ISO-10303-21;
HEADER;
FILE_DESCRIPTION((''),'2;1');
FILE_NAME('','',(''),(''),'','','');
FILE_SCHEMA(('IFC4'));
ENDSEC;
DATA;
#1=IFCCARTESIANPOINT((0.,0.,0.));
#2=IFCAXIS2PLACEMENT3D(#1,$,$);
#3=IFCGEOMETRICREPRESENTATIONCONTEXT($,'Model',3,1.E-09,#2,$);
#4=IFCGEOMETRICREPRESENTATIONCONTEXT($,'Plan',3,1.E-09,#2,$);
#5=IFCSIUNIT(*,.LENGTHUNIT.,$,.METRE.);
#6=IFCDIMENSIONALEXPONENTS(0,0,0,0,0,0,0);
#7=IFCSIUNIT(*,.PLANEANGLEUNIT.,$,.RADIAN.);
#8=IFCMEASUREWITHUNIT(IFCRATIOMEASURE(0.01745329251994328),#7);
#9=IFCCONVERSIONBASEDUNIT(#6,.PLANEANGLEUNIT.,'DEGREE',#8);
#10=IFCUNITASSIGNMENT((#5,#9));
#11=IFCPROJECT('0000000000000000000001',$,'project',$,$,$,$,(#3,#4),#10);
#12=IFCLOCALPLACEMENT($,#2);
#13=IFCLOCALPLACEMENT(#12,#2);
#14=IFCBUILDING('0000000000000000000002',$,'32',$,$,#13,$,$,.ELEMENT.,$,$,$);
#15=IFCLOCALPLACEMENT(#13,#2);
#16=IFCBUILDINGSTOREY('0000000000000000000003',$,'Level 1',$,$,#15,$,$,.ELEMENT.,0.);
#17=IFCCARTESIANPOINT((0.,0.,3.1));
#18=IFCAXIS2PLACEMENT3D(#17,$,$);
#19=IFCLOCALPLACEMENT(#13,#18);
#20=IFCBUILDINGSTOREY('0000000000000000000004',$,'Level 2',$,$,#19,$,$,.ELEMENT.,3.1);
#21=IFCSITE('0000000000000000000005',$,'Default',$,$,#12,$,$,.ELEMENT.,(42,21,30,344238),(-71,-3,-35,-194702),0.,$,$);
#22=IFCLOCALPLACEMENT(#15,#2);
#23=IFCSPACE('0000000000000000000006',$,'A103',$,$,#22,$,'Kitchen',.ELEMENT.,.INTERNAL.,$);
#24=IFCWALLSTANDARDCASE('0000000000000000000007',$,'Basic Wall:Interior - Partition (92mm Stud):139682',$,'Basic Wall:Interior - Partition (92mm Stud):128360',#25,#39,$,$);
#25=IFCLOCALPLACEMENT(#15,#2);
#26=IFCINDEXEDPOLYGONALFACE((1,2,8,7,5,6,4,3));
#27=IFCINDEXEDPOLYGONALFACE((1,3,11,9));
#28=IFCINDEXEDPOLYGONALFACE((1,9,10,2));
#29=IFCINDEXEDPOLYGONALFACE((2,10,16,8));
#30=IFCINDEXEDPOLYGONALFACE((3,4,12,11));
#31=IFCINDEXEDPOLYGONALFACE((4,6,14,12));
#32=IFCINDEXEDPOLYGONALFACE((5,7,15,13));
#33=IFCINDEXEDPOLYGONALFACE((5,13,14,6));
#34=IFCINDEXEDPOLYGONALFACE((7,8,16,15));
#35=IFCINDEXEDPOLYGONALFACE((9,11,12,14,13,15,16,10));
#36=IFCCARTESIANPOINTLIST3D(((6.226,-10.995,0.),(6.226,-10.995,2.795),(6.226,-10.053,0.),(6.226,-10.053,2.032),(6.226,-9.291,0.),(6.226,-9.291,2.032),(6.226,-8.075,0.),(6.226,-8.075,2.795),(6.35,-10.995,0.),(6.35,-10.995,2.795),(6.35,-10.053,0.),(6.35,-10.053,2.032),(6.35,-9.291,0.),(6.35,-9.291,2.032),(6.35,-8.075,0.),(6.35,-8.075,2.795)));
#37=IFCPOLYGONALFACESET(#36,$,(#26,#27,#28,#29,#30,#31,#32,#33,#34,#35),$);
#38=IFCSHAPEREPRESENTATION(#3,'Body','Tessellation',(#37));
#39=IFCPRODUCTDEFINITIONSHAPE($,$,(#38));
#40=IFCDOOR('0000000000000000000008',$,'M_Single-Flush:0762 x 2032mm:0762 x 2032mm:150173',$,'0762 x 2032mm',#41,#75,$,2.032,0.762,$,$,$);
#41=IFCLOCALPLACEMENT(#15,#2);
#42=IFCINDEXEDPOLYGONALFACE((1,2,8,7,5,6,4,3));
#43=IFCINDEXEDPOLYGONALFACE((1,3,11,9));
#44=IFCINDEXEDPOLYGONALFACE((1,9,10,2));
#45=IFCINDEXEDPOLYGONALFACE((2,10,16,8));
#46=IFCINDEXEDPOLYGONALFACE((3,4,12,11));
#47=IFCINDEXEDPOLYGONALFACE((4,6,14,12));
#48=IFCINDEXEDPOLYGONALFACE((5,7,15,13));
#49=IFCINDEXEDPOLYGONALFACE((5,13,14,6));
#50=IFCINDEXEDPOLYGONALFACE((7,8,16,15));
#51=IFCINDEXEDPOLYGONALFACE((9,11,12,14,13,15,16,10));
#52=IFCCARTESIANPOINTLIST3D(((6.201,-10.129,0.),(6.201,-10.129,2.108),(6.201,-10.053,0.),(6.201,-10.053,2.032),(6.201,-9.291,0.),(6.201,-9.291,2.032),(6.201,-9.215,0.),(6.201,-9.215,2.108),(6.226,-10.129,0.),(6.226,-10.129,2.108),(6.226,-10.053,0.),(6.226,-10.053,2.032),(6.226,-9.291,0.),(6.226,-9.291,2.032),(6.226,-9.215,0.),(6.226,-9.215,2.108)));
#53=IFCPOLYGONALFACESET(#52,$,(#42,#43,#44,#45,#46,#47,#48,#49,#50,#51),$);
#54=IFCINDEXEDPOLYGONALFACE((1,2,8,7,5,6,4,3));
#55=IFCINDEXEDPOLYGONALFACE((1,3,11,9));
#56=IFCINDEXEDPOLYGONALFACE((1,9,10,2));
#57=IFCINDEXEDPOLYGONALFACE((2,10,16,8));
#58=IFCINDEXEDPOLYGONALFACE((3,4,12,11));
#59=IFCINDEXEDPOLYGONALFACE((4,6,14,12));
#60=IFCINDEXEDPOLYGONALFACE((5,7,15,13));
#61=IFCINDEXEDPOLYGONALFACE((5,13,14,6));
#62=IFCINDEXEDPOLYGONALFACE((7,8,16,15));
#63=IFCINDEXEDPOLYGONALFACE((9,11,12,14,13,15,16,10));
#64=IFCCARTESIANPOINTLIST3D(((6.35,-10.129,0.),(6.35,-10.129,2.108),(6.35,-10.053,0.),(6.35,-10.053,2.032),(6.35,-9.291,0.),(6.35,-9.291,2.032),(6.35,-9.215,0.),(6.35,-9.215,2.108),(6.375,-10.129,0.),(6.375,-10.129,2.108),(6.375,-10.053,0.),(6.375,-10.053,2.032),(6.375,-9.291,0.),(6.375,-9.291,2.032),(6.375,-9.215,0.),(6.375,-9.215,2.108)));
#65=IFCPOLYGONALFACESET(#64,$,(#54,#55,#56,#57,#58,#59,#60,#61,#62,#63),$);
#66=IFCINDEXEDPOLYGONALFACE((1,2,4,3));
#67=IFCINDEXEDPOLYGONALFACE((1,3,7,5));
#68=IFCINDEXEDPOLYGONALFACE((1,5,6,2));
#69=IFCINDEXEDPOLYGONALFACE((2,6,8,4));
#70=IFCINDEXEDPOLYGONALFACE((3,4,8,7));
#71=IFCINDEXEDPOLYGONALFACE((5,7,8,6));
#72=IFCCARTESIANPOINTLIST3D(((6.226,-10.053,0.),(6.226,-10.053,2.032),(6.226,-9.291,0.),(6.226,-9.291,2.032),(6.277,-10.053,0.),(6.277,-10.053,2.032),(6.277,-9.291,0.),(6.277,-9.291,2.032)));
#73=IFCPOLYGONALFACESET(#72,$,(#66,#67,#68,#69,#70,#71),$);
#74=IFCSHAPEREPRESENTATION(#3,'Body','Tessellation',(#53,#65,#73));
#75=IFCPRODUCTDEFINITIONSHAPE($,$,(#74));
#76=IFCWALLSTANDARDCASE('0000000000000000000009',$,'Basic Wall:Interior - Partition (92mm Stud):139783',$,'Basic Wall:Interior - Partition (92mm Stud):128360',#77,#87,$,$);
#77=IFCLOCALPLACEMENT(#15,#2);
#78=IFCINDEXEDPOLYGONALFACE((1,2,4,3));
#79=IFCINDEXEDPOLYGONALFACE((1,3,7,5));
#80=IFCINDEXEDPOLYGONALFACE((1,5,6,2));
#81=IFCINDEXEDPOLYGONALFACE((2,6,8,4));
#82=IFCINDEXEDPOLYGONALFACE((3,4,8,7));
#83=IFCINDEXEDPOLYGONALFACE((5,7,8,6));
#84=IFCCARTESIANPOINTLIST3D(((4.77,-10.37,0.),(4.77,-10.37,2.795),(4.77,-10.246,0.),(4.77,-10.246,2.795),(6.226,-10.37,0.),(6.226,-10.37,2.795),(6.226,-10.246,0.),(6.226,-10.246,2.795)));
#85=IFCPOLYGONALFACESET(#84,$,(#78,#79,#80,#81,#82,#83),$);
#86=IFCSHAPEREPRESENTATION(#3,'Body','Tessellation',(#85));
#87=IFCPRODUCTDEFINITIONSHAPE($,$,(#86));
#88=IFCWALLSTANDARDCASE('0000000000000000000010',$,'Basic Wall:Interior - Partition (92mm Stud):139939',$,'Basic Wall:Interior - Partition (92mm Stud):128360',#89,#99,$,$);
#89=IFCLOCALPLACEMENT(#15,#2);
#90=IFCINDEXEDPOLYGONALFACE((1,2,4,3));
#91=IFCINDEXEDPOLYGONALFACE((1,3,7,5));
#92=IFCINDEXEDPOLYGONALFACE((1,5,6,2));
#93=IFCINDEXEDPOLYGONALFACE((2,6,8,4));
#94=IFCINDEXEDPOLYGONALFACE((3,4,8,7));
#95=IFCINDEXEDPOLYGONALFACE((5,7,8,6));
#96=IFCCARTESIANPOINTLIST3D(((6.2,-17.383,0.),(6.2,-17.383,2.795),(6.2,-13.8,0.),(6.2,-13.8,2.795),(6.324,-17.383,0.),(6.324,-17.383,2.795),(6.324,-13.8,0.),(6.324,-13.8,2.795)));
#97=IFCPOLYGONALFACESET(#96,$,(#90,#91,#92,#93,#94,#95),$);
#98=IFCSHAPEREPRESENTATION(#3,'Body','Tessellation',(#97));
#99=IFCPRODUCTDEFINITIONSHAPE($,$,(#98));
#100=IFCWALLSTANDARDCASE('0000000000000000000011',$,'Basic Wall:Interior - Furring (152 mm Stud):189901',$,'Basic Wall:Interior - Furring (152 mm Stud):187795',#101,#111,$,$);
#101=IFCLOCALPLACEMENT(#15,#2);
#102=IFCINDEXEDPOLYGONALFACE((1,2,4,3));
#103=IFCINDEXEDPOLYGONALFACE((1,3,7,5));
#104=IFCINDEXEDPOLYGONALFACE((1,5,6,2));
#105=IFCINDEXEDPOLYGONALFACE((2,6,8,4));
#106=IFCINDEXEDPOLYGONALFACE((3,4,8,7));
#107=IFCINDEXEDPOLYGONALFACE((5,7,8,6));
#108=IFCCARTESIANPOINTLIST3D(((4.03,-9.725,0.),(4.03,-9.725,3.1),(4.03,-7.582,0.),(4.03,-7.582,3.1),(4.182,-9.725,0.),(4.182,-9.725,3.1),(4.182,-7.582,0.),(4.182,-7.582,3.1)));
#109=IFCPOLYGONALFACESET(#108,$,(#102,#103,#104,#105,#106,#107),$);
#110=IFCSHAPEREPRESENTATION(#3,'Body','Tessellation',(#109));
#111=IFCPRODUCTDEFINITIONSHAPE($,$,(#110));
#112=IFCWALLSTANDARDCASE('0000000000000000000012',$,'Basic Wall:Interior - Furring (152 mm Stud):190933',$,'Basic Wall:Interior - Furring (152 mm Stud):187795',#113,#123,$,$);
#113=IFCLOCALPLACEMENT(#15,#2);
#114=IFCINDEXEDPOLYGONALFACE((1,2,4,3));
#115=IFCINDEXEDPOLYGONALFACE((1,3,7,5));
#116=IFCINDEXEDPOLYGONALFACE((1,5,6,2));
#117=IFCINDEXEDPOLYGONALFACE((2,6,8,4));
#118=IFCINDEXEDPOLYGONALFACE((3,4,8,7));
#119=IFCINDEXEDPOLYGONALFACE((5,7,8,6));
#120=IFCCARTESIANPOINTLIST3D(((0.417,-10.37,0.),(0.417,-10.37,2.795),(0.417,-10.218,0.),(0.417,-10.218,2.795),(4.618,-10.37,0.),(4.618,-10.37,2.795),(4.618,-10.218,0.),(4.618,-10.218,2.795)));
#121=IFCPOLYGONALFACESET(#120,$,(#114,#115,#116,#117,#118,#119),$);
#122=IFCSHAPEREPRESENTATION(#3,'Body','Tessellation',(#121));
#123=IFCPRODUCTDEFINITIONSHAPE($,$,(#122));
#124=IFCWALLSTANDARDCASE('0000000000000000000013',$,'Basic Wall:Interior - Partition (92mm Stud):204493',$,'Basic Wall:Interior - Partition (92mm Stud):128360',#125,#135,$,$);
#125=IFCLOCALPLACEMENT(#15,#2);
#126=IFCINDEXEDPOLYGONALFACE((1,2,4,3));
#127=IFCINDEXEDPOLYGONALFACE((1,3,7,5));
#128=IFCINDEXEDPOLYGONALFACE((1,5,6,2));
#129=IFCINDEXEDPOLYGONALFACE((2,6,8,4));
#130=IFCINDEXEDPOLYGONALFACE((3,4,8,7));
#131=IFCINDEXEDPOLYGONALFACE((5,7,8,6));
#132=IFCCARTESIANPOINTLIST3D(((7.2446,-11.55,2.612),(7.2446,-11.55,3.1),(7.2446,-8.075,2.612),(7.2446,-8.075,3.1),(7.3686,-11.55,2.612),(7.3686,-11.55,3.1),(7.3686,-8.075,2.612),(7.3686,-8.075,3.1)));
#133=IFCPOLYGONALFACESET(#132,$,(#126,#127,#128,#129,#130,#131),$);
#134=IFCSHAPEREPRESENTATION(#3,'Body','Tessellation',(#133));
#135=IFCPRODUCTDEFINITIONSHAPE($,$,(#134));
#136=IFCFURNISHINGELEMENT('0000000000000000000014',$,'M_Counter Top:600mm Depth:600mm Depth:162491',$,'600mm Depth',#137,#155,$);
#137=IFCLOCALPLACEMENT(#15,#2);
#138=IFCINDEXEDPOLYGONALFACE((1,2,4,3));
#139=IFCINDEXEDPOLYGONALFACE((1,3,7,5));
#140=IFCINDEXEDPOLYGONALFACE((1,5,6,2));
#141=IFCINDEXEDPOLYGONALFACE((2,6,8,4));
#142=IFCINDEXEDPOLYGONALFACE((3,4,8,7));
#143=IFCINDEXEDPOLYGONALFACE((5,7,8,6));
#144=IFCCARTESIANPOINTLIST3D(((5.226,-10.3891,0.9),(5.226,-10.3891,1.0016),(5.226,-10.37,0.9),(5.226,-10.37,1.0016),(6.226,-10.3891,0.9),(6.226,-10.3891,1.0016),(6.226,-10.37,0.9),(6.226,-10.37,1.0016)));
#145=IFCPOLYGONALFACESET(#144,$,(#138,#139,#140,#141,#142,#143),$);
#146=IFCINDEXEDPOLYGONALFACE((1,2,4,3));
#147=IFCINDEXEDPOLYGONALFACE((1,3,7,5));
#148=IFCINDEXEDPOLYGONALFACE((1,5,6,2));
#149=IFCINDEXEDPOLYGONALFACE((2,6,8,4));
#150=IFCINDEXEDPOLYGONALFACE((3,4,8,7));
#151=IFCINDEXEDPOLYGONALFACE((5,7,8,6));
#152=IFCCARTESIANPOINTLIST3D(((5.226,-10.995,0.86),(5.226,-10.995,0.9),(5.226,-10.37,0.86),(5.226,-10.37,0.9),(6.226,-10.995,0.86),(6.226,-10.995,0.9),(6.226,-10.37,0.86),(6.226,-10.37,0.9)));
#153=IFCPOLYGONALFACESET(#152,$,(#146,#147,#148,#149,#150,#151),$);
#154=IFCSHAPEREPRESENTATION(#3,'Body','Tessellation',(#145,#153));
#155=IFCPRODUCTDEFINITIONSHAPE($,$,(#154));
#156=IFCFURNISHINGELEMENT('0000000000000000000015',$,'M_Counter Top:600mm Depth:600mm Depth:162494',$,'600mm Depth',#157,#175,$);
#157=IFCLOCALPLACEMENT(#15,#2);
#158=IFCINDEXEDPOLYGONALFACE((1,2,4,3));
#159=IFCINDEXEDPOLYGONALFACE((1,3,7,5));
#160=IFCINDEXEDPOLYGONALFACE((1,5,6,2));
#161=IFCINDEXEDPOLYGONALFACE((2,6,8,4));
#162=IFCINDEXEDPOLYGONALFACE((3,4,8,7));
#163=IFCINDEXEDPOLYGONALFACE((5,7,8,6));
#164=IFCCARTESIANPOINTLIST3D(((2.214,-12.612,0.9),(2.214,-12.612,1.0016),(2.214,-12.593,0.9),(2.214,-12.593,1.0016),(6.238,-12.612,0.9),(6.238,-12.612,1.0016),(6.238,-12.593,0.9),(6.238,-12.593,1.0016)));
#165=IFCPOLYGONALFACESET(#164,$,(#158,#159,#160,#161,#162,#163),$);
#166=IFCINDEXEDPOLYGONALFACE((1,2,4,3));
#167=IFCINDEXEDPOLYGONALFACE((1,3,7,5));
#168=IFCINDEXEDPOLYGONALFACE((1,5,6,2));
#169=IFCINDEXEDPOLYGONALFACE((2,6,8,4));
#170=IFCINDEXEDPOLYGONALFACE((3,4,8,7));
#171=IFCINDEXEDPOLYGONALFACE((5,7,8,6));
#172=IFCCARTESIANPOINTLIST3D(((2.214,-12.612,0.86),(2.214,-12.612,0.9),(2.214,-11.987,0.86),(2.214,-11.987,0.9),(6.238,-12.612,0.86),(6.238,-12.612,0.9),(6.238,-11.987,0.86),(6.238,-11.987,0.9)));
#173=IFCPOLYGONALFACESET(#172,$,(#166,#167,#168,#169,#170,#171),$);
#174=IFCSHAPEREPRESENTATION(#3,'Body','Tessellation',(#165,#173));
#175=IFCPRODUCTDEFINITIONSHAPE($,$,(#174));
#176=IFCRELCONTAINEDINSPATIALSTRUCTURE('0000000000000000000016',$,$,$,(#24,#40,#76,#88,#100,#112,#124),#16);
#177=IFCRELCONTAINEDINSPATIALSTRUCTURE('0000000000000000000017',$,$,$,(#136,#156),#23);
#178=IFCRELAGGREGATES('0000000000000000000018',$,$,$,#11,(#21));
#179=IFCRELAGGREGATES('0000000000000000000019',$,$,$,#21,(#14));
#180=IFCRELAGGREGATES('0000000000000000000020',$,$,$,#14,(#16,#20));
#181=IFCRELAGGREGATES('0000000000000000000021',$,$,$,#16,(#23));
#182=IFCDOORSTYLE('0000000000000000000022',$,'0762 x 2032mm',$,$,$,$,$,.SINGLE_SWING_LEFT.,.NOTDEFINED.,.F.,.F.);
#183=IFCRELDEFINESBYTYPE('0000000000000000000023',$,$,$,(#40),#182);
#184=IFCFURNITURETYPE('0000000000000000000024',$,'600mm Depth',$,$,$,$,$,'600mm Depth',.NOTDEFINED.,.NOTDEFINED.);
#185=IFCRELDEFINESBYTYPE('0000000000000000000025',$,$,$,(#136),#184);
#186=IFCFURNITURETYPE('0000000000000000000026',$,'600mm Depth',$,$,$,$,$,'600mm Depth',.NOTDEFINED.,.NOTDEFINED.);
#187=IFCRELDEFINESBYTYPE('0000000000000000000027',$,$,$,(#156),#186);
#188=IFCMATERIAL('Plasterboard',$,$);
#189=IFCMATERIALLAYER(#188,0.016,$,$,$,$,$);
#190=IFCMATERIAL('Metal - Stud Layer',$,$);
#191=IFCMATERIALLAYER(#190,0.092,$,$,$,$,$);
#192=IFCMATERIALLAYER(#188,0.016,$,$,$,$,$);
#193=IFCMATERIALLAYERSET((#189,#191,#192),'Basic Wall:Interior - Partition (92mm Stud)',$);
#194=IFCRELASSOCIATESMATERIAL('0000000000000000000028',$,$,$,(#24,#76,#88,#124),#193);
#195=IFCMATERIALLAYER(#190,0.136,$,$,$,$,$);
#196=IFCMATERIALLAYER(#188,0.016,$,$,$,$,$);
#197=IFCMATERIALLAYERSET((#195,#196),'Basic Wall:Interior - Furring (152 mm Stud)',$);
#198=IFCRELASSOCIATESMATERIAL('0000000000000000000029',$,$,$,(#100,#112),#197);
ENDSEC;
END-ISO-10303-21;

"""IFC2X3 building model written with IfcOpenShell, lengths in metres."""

from ifc_helpers import new_model, entity, si_unit, converted_unit, frame, frame_2d, origin, origin_2d_with_axis, place, context, project, spatial, polyline, rectangle, outline, extrude, source, transform, mapped, material, layer, layer_set, layer_usage, type_object, type_shapes, element, fill, save


model = new_model("IFC2X3")

# Units and contexts
model_context = context("Model", 3, precision=1e-09, world=origin())
plan_context = context("Plan", 3, precision=1e-09, world=origin())
ifc_project = project(units=[si_unit("LENGTHUNIT", "METRE"), converted_unit("PLANEANGLEUNIT", "DEGREE", entity("IfcRatioMeasure", 0.01745329251994328), si_unit("PLANEANGLEUNIT", "RADIAN"), dimensions=[0, 0, 0, 0, 0, 0, 0])], contexts=[model_context, plan_context])

# Site, building, storey
site_placement = place(None, origin())
site = spatial("IfcSite", under=ifc_project, at=site_placement, Name="Default", CompositionType="ELEMENT", RefLatitude=(42, 21, 30, 344238), RefLongitude=(-71, -3, -35, -194702), RefElevation=0.0)
building_placement = place(site_placement, origin())
building = spatial("IfcBuilding", under=site, at=building_placement, Name="32", CompositionType="ELEMENT")
storey_1_placement = place(building_placement, origin())
storey_1 = spatial("IfcBuildingStorey", under=building, at=storey_1_placement, Name="Level 1", CompositionType="ELEMENT", Elevation=0.0)

# Shared definitions
ifc_material_1 = material(Name="Metal - Stud Layer")
ifc_material_2 = material(Name="Plasterboard")

# Wall, opening, door
ifc_layer_1 = layer(ifc_material_2, 0.016)
ifc_layer_2 = layer(ifc_material_1, 0.092)
ifc_layer_3 = layer(ifc_material_2, 0.016)
ifc_layer_set_1 = layer_set([ifc_layer_1, ifc_layer_2, ifc_layer_3], Name="Basic Wall:Interior - Partition (92mm Stud)")
ifc_layer_usage_1 = layer_usage(ifc_layer_set_1, "AXIS2", "NEGATIVE", 0.062)
wall_1_placement = place(storey_1_placement, frame((6.288, -10.995, 0.0), z_axis=(0.0, 0.0, 1.0), x_axis=(0.0, 1.0, 0.0)))
wall_1 = element("IfcWallStandardCase", 1, at=wall_1_placement, inside=storey_1, material=ifc_layer_usage_1, Name="Basic Wall:Interior - Partition (92mm Stud):139682", ObjectType="Basic Wall:Interior - Partition (92mm Stud):128360", context=model_context, shape_type="SweptSolid", body=[
    extrude(rectangle(XDim=2.92, YDim=0.124, at=frame_2d((1.46, 0.0), x_axis=(-1.0, 0.0))), origin(), (0.0, 0.0, 1.0), 2.795),
])
opening_1_placement = place(wall_1_placement, frame((0.942, -0.062, 0.0)))
opening_1 = element("IfcOpeningElement", 2, at=opening_1_placement, cuts=wall_1, ObjectType="Opening", context=model_context, shape_type="SweptSolid", body=[
    extrude(rectangle(XDim=0.762, YDim=2.032, at=frame_2d((1.016, 0.381), x_axis=(0.0, -1.0))), frame((0.0, 0.0, 0.0), z_axis=(0.0, 1.0, 0.0), x_axis=(0.0, 0.0, 1.0)), (0.0, 0.0, 1.0), 0.124),
])
door_style_1 = type_object("IfcDoorStyle", Name="0762 x 2032mm", ConstructionType="NOTDEFINED", OperationType="SINGLE_SWING_LEFT", ParameterTakesPrecedence=False, Sizeable=False)
shared_shape_1 = source(origin(), model_context, "Body", "SweptSolid", [
    extrude(outline(polyline([(-0.457, -1.073), (0.457, -1.073), (0.457, 1.035), (0.381, 1.035), (0.381, -0.997), (-0.381, -0.997), (-0.381, 1.035), (-0.457, 1.035), (-0.457, -1.073)])), frame((0.381, 0.149, 1.035), z_axis=(0.0, -1.0, 0.0), x_axis=(-1.0, 0.0, 0.0)), (0.0, 0.0, 1.0), 0.025),
    extrude(outline(polyline([(-1.073, -0.457), (1.035, -0.457), (1.035, -0.381), (-0.997, -0.381), (-0.997, 0.381), (1.035, 0.381), (1.035, 0.457), (-1.073, 0.457), (-1.073, -0.457)])), frame((0.381, 0.0, 1.035), z_axis=(0.0, -1.0, 0.0), x_axis=(0.0, 0.0, -1.0)), (0.0, 0.0, 1.0), 0.025),
    extrude(rectangle(XDim=0.762, YDim=0.051, at=origin_2d_with_axis()), frame((0.381, 0.0985, 0.0)), (0.0, 0.0, 1.0), 2.032),
])
type_shapes(door_style_1, [shared_shape_1])
door_1_placement = place(opening_1_placement, origin())
door_1 = element("IfcDoor", 3, at=door_1_placement, inside=storey_1, type_object=door_style_1, Name="M_Single-Flush:0762 x 2032mm:0762 x 2032mm:150173", ObjectType="0762 x 2032mm", OverallHeight=2.032, OverallWidth=0.762, context=model_context, shape_type="MappedRepresentation", body=[
    mapped(shared_shape_1, transform((0.0, 0.0, 0.0), scale=1.0)),
])
fill(opening_1, door_1)

# Walls
ifc_layer_usage_2 = layer_usage(ifc_layer_set_1, "AXIS2", "NEGATIVE", 0.062)
wall_2_placement = place(storey_1_placement, frame((4.77, -10.308, 0.0)))
element("IfcWallStandardCase", 4, at=wall_2_placement, inside=storey_1, material=ifc_layer_usage_2, Name="Basic Wall:Interior - Partition (92mm Stud):139783", ObjectType="Basic Wall:Interior - Partition (92mm Stud):128360", context=model_context, shape_type="SweptSolid", body=[
    extrude(rectangle(XDim=1.456, YDim=0.124, at=frame_2d((0.728, 0.0), x_axis=(-1.0, 0.0))), origin(), (0.0, 0.0, 1.0), 2.795),
])
ifc_layer_usage_3 = layer_usage(ifc_layer_set_1, "AXIS2", "NEGATIVE", 0.062)
wall_3_placement = place(storey_1_placement, frame((6.262, -13.8, 0.0), z_axis=(0.0, 0.0, 1.0), x_axis=(0.0, -1.0, 0.0)))
element("IfcWallStandardCase", 5, at=wall_3_placement, inside=storey_1, material=ifc_layer_usage_3, Name="Basic Wall:Interior - Partition (92mm Stud):139939", ObjectType="Basic Wall:Interior - Partition (92mm Stud):128360", context=model_context, shape_type="SweptSolid", body=[
    extrude(rectangle(XDim=3.583, YDim=0.124, at=frame_2d((1.7915, 0.0), x_axis=(-1.0, 0.0))), origin(), (0.0, 0.0, 1.0), 2.795),
])

# Shared definitions
storey_2_placement = place(building_placement, frame((0.0, 0.0, 3.1)))
storey_2 = spatial("IfcBuildingStorey", under=building, at=storey_2_placement, Name="Level 2", CompositionType="ELEMENT", Elevation=3.1)

# Walls
ifc_layer_4 = layer(ifc_material_1, 0.136)
ifc_layer_5 = layer(ifc_material_2, 0.016)
ifc_layer_set_2 = layer_set([ifc_layer_4, ifc_layer_5], Name="Basic Wall:Interior - Furring (152 mm Stud)")
ifc_layer_usage_4 = layer_usage(ifc_layer_set_2, "AXIS2", "POSITIVE", -0.076)
wall_4_placement = place(storey_1_placement, frame((4.106, -9.725, 0.0), z_axis=(0.0, 0.0, 1.0), x_axis=(0.0, 1.0, 0.0)))
element("IfcWallStandardCase", 6, at=wall_4_placement, inside=storey_1, material=ifc_layer_usage_4, Name="Basic Wall:Interior - Furring (152 mm Stud):189901", ObjectType="Basic Wall:Interior - Furring (152 mm Stud):187795", context=model_context, shape_type="SweptSolid", body=[
    extrude(rectangle(XDim=2.143, YDim=0.152, at=frame_2d((1.0715, 0.0), x_axis=(-1.0, 0.0))), origin(), (0.0, 0.0, 1.0), 3.1),
])
ifc_layer_usage_5 = layer_usage(ifc_layer_set_2, "AXIS2", "NEGATIVE", 0.076)
wall_5_placement = place(storey_1_placement, frame((0.417, -10.294, 0.0)))
element("IfcWallStandardCase", 7, at=wall_5_placement, inside=storey_1, material=ifc_layer_usage_5, Name="Basic Wall:Interior - Furring (152 mm Stud):190933", ObjectType="Basic Wall:Interior - Furring (152 mm Stud):187795", context=model_context, shape_type="SweptSolid", body=[
    extrude(rectangle(XDim=4.201, YDim=0.152, at=frame_2d((2.1005, 0.0), x_axis=(-1.0, 0.0))), origin(), (0.0, 0.0, 1.0), 2.795),
])
ifc_layer_usage_6 = layer_usage(ifc_layer_set_1, "AXIS2", "NEGATIVE", 0.062)
wall_6_placement = place(storey_1_placement, frame((7.3066, -11.55, 2.612), z_axis=(0.0, 0.0, 1.0), x_axis=(0.0, 1.0, 0.0)))
element("IfcWallStandardCase", 8, at=wall_6_placement, inside=storey_1, material=ifc_layer_usage_6, Name="Basic Wall:Interior - Partition (92mm Stud):204493", ObjectType="Basic Wall:Interior - Partition (92mm Stud):128360", context=model_context, shape_type="SweptSolid", body=[
    extrude(rectangle(XDim=3.475, YDim=0.124, at=frame_2d((1.7375, 0.0), x_axis=(-1.0, 0.0))), origin(), (0.0, 0.0, 1.0), 0.488),
])

# Shared definitions
space_1_placement = place(storey_1_placement, origin())
space_1 = spatial("IfcSpace", under=storey_1, at=space_1_placement, Name="A103", LongName="Kitchen", CompositionType="ELEMENT", InteriorOrExteriorSpace="INTERNAL")

# Furnishing elements
furniture_type_1 = type_object("IfcFurnitureType", Name="600mm Depth", ElementType="600mm Depth", AssemblyPlace="NOTDEFINED")
shared_shape_2 = source(origin(), model_context, "Body", "SweptSolid", [
    extrude(rectangle(XDim=0.0191, YDim=1.0, at=origin_2d_with_axis()), frame((-0.7005, -0.0095, 0.9), z_axis=(0.0, 0.0, 1.0), x_axis=(0.0, -1.0, 0.0)), (0.0, 0.0, 1.0), 0.1016),
    extrude(rectangle(XDim=1.0, YDim=0.625, at=origin_2d_with_axis()), frame((-0.7005, -0.3125, 0.86), z_axis=(0.0, 0.0, 1.0), x_axis=(-1.0, 0.0, 0.0)), (0.0, 0.0, 1.0), 0.04),
])
type_shapes(furniture_type_1, [shared_shape_2])
furnishing_1_placement = place(space_1_placement, frame((6.4265, -10.37, 0.0)))
element("IfcFurnishingElement", 9, at=furnishing_1_placement, inside=space_1, type_object=furniture_type_1, Name="M_Counter Top:600mm Depth:600mm Depth:162491", ObjectType="600mm Depth", context=model_context, shape_type="MappedRepresentation", body=[
    mapped(shared_shape_2, transform((0.0, 0.0, 0.0), scale=1.0)),
])
furniture_type_2 = type_object("IfcFurnitureType", Name="600mm Depth", ElementType="600mm Depth", AssemblyPlace="NOTDEFINED")
shared_shape_3 = source(origin(), model_context, "Body", "SweptSolid", [
    extrude(rectangle(XDim=0.0191, YDim=4.024, at=origin_2d_with_axis()), frame((0.8115, -0.0095, 0.9), z_axis=(0.0, 0.0, 1.0), x_axis=(0.0, -1.0, 0.0)), (0.0, 0.0, 1.0), 0.1016),
    extrude(rectangle(XDim=4.024, YDim=0.625, at=origin_2d_with_axis()), frame((0.8115, -0.3125, 0.86), z_axis=(0.0, 0.0, 1.0), x_axis=(-1.0, 0.0, 0.0)), (0.0, 0.0, 1.0), 0.04),
])
type_shapes(furniture_type_2, [shared_shape_3])
furnishing_2_placement = place(space_1_placement, frame((5.0375, -12.612, 0.0), z_axis=(0.0, 0.0, 1.0), x_axis=(-1.0, 0.0, 0.0)))
element("IfcFurnishingElement", 10, at=furnishing_2_placement, inside=space_1, type_object=furniture_type_2, Name="M_Counter Top:600mm Depth:600mm Depth:162494", ObjectType="600mm Depth", context=model_context, shape_type="MappedRepresentation", body=[
    mapped(shared_shape_3, transform((0.0, 0.0, 0.0), scale=1.0)),
])

save(model, "model.ifc")
